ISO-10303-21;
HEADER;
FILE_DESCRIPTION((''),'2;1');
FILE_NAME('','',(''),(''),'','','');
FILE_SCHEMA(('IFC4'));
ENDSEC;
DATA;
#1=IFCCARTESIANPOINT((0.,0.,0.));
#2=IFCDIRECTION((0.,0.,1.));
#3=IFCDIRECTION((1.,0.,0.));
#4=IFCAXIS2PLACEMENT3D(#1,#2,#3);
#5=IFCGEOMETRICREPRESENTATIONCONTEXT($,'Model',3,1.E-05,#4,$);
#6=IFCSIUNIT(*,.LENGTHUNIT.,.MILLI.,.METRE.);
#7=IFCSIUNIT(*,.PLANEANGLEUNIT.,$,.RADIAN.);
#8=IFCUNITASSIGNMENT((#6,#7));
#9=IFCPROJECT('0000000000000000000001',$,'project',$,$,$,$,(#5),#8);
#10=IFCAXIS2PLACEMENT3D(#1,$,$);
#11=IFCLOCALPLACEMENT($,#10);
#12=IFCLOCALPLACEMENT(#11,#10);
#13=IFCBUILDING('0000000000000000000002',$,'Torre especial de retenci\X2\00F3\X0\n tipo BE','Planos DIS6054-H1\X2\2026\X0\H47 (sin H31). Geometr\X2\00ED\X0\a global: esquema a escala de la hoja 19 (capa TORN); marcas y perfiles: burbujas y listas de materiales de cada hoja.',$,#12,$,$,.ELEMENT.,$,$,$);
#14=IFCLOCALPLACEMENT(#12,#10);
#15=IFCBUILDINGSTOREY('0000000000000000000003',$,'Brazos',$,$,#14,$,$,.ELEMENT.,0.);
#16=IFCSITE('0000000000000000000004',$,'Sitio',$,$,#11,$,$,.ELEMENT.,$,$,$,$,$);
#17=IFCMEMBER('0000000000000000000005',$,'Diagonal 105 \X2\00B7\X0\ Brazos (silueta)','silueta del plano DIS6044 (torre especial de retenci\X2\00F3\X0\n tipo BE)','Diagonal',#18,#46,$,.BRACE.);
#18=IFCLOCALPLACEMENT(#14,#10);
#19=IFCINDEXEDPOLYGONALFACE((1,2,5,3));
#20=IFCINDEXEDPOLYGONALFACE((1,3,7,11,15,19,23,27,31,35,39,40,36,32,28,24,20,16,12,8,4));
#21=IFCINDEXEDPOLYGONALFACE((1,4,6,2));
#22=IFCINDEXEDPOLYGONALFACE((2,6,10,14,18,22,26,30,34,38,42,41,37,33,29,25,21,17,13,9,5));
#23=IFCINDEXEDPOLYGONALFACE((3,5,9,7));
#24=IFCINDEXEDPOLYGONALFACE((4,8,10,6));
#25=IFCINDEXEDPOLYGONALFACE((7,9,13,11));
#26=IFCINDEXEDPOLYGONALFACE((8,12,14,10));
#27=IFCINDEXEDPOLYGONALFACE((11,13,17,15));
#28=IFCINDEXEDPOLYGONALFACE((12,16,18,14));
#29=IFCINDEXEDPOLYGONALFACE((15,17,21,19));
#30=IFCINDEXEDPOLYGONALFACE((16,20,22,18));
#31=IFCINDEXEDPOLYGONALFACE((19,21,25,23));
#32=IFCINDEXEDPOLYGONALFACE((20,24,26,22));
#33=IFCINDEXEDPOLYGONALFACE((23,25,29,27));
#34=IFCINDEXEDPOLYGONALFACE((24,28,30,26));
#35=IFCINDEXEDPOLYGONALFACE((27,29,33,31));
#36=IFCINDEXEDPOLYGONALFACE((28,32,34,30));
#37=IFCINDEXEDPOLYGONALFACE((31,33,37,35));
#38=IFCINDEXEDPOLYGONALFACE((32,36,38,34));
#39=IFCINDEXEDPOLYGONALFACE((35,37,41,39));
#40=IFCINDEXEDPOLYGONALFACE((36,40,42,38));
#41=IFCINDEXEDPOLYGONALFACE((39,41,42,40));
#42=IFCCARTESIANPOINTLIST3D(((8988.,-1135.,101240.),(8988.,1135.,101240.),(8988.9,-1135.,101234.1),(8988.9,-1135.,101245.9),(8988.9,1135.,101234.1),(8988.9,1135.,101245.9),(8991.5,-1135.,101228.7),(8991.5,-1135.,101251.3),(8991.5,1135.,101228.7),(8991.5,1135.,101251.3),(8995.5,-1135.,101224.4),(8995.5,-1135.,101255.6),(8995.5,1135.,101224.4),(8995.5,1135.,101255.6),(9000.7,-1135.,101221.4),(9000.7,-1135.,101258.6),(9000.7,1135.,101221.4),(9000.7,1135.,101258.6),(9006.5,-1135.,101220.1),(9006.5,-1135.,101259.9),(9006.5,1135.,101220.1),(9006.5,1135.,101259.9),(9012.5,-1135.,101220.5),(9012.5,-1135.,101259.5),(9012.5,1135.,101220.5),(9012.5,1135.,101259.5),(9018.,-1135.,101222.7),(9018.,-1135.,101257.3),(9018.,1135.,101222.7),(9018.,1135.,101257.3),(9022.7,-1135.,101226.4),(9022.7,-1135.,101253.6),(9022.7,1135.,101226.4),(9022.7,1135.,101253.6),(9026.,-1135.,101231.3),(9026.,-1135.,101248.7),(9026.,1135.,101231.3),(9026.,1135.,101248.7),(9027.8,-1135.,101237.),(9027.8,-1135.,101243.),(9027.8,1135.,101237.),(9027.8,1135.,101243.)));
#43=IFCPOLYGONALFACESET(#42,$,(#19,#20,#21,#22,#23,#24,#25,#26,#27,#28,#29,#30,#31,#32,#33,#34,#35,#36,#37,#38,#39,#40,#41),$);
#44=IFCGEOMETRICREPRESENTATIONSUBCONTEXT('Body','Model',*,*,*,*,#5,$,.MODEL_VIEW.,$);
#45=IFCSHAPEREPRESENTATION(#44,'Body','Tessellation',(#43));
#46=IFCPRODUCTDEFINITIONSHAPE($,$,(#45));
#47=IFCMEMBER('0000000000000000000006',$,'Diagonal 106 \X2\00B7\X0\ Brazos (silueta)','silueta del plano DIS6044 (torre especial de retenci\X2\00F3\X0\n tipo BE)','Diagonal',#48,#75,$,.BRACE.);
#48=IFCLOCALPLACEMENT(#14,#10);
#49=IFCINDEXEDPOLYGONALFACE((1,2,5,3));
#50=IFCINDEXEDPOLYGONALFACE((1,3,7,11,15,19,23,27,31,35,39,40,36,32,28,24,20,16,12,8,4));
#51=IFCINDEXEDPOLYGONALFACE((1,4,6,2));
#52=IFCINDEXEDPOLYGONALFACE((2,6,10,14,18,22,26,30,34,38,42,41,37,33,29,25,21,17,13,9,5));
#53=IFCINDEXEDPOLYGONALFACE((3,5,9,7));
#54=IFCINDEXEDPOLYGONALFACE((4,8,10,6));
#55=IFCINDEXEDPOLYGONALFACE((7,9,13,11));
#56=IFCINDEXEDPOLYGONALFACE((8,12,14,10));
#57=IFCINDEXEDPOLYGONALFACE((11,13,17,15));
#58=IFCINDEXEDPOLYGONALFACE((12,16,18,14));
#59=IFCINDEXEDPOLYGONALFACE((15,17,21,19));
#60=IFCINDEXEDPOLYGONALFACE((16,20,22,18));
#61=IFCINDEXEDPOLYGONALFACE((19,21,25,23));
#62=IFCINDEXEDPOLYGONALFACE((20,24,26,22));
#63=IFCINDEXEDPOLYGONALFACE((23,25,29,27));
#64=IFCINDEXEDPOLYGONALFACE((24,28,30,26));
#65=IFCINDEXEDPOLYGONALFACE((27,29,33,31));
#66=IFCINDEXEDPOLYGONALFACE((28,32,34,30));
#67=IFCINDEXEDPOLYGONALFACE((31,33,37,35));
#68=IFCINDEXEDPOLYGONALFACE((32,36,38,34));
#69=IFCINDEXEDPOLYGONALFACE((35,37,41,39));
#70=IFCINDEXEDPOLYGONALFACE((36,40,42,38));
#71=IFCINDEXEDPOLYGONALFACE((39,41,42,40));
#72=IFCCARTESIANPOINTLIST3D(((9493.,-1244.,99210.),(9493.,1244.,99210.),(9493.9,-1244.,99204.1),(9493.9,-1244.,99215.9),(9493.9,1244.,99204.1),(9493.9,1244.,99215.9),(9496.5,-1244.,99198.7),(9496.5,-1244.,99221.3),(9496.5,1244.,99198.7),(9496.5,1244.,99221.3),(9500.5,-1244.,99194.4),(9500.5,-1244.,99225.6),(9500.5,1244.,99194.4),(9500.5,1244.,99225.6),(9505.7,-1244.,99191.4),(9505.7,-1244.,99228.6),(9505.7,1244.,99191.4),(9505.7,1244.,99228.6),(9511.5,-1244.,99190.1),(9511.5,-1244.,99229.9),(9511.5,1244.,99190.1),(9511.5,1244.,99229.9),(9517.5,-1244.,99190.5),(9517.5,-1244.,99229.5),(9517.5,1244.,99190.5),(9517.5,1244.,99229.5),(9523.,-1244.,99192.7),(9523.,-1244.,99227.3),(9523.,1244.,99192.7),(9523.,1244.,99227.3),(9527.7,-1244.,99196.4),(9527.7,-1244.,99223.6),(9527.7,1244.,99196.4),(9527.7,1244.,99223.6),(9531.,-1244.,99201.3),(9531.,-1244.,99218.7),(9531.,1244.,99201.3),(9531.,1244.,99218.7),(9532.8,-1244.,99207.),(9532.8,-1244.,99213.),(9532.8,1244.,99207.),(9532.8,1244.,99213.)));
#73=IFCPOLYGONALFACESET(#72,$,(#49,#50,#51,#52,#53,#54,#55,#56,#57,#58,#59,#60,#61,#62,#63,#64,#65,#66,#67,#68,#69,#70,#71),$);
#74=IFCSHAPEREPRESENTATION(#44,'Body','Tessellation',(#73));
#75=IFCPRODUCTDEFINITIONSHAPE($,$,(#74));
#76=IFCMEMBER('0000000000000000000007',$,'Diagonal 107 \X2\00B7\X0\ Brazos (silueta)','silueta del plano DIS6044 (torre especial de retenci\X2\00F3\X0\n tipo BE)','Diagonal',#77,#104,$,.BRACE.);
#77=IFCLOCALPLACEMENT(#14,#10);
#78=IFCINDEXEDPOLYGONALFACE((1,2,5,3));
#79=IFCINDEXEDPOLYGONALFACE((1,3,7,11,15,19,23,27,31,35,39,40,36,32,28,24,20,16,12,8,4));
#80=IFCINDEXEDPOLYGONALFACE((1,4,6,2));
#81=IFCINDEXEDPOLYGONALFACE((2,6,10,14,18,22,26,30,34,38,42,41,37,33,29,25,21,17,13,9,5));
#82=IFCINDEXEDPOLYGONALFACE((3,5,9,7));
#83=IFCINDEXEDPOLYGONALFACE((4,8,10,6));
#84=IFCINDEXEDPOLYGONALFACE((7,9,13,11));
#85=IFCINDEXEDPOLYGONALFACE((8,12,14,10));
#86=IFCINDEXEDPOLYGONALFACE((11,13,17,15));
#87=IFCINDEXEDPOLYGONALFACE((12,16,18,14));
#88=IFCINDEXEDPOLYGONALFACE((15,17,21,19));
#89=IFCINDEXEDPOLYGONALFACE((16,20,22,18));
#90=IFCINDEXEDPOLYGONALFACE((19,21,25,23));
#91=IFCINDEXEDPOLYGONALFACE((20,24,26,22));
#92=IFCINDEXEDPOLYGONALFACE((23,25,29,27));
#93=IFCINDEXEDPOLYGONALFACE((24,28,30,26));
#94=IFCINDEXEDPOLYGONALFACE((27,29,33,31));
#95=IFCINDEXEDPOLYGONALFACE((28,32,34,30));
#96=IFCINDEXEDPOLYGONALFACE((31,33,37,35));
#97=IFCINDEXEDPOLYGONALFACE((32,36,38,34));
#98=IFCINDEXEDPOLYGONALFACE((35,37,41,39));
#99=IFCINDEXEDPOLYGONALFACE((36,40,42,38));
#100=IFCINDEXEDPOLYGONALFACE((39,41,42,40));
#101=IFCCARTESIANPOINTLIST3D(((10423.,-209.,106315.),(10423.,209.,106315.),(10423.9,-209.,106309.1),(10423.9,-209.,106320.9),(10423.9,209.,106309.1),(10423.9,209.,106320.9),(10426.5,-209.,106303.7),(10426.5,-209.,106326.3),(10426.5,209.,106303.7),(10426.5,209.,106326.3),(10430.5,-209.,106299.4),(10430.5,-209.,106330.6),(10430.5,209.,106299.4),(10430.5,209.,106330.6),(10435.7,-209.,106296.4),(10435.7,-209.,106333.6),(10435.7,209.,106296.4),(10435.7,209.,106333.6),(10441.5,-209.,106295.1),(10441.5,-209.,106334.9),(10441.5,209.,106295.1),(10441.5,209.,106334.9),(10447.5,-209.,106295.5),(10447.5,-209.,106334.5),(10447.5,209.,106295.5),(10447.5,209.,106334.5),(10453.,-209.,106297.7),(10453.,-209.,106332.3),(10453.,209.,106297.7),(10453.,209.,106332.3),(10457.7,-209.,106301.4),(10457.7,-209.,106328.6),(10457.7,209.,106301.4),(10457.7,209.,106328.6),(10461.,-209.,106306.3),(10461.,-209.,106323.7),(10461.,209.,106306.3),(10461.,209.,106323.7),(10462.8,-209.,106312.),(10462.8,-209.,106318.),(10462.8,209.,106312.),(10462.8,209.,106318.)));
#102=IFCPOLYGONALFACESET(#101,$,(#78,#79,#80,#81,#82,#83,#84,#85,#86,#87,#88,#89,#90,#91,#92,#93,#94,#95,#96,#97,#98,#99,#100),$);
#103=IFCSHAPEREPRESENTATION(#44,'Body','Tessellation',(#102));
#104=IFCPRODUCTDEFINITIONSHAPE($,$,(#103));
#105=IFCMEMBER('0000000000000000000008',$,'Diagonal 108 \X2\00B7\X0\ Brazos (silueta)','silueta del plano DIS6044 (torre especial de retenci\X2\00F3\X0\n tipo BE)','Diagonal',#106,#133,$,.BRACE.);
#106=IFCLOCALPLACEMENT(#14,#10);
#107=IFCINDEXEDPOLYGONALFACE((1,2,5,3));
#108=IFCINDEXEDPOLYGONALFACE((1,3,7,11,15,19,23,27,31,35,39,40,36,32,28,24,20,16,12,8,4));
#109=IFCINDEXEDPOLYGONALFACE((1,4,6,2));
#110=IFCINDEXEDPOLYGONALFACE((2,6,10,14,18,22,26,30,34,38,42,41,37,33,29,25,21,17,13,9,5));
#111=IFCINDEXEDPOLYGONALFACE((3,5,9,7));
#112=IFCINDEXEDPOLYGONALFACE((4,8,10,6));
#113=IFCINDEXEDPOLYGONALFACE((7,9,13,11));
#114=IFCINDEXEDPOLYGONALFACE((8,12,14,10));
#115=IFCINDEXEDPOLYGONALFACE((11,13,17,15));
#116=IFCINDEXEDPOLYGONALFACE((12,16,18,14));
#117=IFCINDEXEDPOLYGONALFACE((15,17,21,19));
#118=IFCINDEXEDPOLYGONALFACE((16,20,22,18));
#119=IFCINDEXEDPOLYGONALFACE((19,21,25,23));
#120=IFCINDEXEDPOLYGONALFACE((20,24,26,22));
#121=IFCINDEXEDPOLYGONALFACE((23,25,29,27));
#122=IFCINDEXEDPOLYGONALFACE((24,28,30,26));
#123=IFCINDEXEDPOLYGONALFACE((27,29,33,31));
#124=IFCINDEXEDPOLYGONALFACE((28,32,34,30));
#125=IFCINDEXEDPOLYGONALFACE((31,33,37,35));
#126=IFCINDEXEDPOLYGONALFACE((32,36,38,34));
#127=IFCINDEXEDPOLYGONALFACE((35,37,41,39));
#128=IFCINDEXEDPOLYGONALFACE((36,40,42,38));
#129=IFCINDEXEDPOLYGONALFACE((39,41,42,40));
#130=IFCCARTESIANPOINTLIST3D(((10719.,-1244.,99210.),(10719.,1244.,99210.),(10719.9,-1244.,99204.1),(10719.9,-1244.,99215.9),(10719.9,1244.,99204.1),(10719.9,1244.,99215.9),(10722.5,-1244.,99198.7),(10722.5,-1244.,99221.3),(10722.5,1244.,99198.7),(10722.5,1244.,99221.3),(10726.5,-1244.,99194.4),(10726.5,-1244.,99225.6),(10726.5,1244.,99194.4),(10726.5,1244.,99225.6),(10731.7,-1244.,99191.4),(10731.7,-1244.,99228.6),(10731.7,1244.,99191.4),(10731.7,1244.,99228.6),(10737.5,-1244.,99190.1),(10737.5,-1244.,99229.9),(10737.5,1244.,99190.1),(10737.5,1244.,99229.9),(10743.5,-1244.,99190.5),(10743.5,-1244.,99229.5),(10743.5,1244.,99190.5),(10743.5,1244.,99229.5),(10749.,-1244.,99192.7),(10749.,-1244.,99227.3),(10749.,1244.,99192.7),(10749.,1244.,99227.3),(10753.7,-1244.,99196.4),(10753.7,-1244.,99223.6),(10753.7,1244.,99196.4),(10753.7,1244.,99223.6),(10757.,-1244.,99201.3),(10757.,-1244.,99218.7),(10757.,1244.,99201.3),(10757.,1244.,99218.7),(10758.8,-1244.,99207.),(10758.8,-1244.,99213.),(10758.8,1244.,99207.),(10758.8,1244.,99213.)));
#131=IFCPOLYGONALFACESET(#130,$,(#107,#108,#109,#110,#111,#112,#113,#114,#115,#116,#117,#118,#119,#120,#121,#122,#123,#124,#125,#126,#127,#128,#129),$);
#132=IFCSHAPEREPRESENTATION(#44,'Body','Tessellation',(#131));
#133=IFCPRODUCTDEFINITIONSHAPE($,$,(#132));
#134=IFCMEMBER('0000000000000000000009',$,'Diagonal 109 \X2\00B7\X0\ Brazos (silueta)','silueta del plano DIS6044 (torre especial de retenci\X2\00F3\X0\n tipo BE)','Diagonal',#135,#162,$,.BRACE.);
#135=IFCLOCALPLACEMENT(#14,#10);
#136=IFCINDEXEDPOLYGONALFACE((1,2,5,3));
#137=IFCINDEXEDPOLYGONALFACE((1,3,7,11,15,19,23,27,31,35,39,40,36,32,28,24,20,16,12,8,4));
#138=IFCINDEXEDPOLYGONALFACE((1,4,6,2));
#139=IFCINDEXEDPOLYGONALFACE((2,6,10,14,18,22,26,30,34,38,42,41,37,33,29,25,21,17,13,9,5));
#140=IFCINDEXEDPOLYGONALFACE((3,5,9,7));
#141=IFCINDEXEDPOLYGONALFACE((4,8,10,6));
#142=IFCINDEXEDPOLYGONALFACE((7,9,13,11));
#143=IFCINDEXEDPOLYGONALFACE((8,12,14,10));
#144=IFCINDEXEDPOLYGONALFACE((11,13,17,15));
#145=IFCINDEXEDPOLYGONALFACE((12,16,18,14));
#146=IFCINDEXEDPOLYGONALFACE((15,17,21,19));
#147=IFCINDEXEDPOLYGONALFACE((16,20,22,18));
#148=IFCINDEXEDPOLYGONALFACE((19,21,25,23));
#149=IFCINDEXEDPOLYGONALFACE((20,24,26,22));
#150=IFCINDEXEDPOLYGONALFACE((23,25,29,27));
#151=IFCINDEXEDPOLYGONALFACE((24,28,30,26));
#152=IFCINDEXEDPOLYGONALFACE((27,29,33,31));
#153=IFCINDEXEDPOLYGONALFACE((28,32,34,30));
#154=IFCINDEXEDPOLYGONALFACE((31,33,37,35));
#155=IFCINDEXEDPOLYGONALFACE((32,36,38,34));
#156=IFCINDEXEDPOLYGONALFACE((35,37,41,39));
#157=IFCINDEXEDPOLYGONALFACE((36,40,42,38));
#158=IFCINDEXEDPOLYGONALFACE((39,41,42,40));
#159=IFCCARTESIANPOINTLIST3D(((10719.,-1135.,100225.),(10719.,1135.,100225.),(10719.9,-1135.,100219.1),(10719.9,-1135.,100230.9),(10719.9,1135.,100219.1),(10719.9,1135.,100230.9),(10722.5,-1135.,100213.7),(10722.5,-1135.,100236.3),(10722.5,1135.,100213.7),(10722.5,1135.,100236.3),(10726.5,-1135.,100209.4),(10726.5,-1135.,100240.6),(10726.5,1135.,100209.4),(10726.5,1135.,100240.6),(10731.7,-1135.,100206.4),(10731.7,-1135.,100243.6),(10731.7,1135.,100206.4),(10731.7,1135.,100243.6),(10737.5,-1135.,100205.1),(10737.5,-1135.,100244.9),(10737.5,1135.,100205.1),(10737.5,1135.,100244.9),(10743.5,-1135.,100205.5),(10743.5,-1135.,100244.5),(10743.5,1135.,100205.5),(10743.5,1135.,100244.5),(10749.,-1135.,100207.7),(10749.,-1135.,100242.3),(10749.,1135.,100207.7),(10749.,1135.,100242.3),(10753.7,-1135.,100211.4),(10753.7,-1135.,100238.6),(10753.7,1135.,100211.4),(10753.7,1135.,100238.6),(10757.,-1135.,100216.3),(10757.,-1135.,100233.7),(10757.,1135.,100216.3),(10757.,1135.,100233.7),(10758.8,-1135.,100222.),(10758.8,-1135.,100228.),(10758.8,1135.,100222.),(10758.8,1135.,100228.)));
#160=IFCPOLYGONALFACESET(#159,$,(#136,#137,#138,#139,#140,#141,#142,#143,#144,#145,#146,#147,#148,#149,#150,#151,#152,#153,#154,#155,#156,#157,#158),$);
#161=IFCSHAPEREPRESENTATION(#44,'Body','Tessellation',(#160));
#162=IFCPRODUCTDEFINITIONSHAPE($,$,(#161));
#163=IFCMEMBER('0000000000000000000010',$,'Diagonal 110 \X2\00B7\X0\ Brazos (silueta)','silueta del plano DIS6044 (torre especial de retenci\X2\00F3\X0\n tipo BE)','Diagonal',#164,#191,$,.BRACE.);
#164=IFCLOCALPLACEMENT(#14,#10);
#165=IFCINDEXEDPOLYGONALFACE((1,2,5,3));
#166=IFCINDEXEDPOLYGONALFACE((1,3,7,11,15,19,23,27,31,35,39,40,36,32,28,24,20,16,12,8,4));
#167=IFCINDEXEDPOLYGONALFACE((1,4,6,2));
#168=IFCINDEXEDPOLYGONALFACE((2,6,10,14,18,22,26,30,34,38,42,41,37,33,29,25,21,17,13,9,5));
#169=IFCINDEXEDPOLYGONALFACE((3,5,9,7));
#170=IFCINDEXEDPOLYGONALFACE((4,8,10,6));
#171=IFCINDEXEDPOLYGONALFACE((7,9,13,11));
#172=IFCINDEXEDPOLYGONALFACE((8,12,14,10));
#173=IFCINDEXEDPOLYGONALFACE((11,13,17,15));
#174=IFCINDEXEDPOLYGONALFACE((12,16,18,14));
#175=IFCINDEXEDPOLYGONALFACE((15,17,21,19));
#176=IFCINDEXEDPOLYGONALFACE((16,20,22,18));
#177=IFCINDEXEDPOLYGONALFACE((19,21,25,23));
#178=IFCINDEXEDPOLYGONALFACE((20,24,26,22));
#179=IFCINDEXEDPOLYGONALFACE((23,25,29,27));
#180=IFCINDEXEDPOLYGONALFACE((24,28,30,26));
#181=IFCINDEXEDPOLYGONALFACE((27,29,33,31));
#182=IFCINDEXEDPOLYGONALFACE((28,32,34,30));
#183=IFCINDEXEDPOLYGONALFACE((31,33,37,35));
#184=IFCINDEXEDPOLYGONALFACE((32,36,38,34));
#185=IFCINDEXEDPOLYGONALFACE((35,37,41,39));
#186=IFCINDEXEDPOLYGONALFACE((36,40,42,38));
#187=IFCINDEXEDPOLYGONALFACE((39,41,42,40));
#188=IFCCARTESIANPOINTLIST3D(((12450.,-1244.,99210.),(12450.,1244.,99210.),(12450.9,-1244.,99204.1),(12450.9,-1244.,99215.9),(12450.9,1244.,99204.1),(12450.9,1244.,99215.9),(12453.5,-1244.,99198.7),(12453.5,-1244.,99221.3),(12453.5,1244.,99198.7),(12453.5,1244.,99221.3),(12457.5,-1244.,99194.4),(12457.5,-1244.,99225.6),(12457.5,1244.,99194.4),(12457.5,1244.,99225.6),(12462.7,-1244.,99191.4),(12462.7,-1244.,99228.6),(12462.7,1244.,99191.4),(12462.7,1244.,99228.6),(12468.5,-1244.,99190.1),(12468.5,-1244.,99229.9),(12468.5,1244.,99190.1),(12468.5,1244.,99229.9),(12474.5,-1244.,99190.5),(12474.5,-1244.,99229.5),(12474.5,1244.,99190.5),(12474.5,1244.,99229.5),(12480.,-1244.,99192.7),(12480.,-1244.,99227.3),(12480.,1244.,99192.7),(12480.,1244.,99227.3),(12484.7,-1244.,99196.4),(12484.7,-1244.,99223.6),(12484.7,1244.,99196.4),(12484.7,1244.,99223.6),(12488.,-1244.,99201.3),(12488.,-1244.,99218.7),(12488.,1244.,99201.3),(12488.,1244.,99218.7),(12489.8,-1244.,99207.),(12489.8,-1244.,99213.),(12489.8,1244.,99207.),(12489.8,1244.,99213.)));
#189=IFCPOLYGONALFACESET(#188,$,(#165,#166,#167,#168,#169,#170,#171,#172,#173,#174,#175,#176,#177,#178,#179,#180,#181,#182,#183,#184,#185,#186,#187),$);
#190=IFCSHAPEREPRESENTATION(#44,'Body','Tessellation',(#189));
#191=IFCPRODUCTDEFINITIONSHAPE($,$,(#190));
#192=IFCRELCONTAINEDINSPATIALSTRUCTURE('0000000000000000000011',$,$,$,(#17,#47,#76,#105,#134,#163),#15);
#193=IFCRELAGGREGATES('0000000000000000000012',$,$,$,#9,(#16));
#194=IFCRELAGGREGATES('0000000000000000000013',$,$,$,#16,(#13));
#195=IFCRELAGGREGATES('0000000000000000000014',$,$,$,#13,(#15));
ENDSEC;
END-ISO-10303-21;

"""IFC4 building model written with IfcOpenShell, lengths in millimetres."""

from ifc_helpers import new_model, si_unit, frame, origin, origin_with_axes, place, context, subcontext, project, spatial, circle, extrude, element, save


model = new_model("IFC4")

# Units and contexts
model_context = context("Model", 3, precision=1e-05, world=origin_with_axes())
body_context = subcontext(model_context, "Body", "Model", "MODEL_VIEW")
ifc_project = project(units=[si_unit("LENGTHUNIT", "METRE", prefix="MILLI"), si_unit("PLANEANGLEUNIT", "RADIAN")], contexts=[model_context])

# Site, building, storey
site_placement = place(None, origin())
site = spatial("IfcSite", under=ifc_project, at=site_placement, Name="Sitio", CompositionType="ELEMENT")
building_placement = place(site_placement, origin())
building = spatial("IfcBuilding", under=site, at=building_placement, Name="Torre especial de retención tipo BE", Description="Planos DIS6054-H1…H47 (sin H31). Geometría global: esquema a escala de la hoja 19 (capa TORN); marcas y perfiles: burbujas y listas de materiales de cada hoja.", CompositionType="ELEMENT")
storey_placement = place(building_placement, origin())
storey = spatial("IfcBuildingStorey", under=building, at=storey_placement, Name="Brazos", CompositionType="ELEMENT", Elevation=0.0)

# Members
member_1_placement = place(storey_placement, frame((9008.0, 1135.0, 101240.0), z_axis=(0.0, -1.0, 0.0), x_axis=(-1.0, 0.0, 0.0)))
element("IfcMember", 1, at=member_1_placement, inside=storey, Name="Diagonal 105 · Brazos (silueta)", Description="silueta del plano DIS6044 (torre especial de retención tipo BE)", ObjectType="Diagonal", PredefinedType="BRACE", context=body_context, shape_type="SweptSolid", body=[
    extrude(circle(Radius=20.0), None, (0.0, 0.0, 1.0), 2270.0),
])
member_2_placement = place(storey_placement, frame((9513.0, 1244.0, 99210.0), z_axis=(0.0, -1.0, 0.0), x_axis=(-1.0, 0.0, 0.0)))
element("IfcMember", 2, at=member_2_placement, inside=storey, Name="Diagonal 106 · Brazos (silueta)", Description="silueta del plano DIS6044 (torre especial de retención tipo BE)", ObjectType="Diagonal", PredefinedType="BRACE", context=body_context, shape_type="SweptSolid", body=[
    extrude(circle(Radius=20.0), None, (0.0, 0.0, 1.0), 2488.0),
])
member_3_placement = place(storey_placement, frame((10443.0, 209.0, 106315.0), z_axis=(0.0, -1.0, 0.0), x_axis=(-1.0, 0.0, 0.0)))
element("IfcMember", 3, at=member_3_placement, inside=storey, Name="Diagonal 107 · Brazos (silueta)", Description="silueta del plano DIS6044 (torre especial de retención tipo BE)", ObjectType="Diagonal", PredefinedType="BRACE", context=body_context, shape_type="SweptSolid", body=[
    extrude(circle(Radius=20.0), None, (0.0, 0.0, 1.0), 418.0),
])
member_4_placement = place(storey_placement, frame((10739.0, 1244.0, 99210.0), z_axis=(0.0, -1.0, 0.0), x_axis=(-1.0, 0.0, 0.0)))
element("IfcMember", 4, at=member_4_placement, inside=storey, Name="Diagonal 108 · Brazos (silueta)", Description="silueta del plano DIS6044 (torre especial de retención tipo BE)", ObjectType="Diagonal", PredefinedType="BRACE", context=body_context, shape_type="SweptSolid", body=[
    extrude(circle(Radius=20.0), None, (0.0, 0.0, 1.0), 2488.0),
])
member_5_placement = place(storey_placement, frame((10739.0, 1135.0, 100225.0), z_axis=(0.0, -1.0, 0.0), x_axis=(-1.0, 0.0, 0.0)))
element("IfcMember", 5, at=member_5_placement, inside=storey, Name="Diagonal 109 · Brazos (silueta)", Description="silueta del plano DIS6044 (torre especial de retención tipo BE)", ObjectType="Diagonal", PredefinedType="BRACE", context=body_context, shape_type="SweptSolid", body=[
    extrude(circle(Radius=20.0), None, (0.0, 0.0, 1.0), 2270.0),
])
member_6_placement = place(storey_placement, frame((12470.0, 1244.0, 99210.0), z_axis=(0.0, -1.0, 0.0), x_axis=(-1.0, 0.0, 0.0)))
element("IfcMember", 6, at=member_6_placement, inside=storey, Name="Diagonal 110 · Brazos (silueta)", Description="silueta del plano DIS6044 (torre especial de retención tipo BE)", ObjectType="Diagonal", PredefinedType="BRACE", context=body_context, shape_type="SweptSolid", body=[
    extrude(circle(Radius=20.0), None, (0.0, 0.0, 1.0), 2488.0),
])

save(model, "model.ifc")
